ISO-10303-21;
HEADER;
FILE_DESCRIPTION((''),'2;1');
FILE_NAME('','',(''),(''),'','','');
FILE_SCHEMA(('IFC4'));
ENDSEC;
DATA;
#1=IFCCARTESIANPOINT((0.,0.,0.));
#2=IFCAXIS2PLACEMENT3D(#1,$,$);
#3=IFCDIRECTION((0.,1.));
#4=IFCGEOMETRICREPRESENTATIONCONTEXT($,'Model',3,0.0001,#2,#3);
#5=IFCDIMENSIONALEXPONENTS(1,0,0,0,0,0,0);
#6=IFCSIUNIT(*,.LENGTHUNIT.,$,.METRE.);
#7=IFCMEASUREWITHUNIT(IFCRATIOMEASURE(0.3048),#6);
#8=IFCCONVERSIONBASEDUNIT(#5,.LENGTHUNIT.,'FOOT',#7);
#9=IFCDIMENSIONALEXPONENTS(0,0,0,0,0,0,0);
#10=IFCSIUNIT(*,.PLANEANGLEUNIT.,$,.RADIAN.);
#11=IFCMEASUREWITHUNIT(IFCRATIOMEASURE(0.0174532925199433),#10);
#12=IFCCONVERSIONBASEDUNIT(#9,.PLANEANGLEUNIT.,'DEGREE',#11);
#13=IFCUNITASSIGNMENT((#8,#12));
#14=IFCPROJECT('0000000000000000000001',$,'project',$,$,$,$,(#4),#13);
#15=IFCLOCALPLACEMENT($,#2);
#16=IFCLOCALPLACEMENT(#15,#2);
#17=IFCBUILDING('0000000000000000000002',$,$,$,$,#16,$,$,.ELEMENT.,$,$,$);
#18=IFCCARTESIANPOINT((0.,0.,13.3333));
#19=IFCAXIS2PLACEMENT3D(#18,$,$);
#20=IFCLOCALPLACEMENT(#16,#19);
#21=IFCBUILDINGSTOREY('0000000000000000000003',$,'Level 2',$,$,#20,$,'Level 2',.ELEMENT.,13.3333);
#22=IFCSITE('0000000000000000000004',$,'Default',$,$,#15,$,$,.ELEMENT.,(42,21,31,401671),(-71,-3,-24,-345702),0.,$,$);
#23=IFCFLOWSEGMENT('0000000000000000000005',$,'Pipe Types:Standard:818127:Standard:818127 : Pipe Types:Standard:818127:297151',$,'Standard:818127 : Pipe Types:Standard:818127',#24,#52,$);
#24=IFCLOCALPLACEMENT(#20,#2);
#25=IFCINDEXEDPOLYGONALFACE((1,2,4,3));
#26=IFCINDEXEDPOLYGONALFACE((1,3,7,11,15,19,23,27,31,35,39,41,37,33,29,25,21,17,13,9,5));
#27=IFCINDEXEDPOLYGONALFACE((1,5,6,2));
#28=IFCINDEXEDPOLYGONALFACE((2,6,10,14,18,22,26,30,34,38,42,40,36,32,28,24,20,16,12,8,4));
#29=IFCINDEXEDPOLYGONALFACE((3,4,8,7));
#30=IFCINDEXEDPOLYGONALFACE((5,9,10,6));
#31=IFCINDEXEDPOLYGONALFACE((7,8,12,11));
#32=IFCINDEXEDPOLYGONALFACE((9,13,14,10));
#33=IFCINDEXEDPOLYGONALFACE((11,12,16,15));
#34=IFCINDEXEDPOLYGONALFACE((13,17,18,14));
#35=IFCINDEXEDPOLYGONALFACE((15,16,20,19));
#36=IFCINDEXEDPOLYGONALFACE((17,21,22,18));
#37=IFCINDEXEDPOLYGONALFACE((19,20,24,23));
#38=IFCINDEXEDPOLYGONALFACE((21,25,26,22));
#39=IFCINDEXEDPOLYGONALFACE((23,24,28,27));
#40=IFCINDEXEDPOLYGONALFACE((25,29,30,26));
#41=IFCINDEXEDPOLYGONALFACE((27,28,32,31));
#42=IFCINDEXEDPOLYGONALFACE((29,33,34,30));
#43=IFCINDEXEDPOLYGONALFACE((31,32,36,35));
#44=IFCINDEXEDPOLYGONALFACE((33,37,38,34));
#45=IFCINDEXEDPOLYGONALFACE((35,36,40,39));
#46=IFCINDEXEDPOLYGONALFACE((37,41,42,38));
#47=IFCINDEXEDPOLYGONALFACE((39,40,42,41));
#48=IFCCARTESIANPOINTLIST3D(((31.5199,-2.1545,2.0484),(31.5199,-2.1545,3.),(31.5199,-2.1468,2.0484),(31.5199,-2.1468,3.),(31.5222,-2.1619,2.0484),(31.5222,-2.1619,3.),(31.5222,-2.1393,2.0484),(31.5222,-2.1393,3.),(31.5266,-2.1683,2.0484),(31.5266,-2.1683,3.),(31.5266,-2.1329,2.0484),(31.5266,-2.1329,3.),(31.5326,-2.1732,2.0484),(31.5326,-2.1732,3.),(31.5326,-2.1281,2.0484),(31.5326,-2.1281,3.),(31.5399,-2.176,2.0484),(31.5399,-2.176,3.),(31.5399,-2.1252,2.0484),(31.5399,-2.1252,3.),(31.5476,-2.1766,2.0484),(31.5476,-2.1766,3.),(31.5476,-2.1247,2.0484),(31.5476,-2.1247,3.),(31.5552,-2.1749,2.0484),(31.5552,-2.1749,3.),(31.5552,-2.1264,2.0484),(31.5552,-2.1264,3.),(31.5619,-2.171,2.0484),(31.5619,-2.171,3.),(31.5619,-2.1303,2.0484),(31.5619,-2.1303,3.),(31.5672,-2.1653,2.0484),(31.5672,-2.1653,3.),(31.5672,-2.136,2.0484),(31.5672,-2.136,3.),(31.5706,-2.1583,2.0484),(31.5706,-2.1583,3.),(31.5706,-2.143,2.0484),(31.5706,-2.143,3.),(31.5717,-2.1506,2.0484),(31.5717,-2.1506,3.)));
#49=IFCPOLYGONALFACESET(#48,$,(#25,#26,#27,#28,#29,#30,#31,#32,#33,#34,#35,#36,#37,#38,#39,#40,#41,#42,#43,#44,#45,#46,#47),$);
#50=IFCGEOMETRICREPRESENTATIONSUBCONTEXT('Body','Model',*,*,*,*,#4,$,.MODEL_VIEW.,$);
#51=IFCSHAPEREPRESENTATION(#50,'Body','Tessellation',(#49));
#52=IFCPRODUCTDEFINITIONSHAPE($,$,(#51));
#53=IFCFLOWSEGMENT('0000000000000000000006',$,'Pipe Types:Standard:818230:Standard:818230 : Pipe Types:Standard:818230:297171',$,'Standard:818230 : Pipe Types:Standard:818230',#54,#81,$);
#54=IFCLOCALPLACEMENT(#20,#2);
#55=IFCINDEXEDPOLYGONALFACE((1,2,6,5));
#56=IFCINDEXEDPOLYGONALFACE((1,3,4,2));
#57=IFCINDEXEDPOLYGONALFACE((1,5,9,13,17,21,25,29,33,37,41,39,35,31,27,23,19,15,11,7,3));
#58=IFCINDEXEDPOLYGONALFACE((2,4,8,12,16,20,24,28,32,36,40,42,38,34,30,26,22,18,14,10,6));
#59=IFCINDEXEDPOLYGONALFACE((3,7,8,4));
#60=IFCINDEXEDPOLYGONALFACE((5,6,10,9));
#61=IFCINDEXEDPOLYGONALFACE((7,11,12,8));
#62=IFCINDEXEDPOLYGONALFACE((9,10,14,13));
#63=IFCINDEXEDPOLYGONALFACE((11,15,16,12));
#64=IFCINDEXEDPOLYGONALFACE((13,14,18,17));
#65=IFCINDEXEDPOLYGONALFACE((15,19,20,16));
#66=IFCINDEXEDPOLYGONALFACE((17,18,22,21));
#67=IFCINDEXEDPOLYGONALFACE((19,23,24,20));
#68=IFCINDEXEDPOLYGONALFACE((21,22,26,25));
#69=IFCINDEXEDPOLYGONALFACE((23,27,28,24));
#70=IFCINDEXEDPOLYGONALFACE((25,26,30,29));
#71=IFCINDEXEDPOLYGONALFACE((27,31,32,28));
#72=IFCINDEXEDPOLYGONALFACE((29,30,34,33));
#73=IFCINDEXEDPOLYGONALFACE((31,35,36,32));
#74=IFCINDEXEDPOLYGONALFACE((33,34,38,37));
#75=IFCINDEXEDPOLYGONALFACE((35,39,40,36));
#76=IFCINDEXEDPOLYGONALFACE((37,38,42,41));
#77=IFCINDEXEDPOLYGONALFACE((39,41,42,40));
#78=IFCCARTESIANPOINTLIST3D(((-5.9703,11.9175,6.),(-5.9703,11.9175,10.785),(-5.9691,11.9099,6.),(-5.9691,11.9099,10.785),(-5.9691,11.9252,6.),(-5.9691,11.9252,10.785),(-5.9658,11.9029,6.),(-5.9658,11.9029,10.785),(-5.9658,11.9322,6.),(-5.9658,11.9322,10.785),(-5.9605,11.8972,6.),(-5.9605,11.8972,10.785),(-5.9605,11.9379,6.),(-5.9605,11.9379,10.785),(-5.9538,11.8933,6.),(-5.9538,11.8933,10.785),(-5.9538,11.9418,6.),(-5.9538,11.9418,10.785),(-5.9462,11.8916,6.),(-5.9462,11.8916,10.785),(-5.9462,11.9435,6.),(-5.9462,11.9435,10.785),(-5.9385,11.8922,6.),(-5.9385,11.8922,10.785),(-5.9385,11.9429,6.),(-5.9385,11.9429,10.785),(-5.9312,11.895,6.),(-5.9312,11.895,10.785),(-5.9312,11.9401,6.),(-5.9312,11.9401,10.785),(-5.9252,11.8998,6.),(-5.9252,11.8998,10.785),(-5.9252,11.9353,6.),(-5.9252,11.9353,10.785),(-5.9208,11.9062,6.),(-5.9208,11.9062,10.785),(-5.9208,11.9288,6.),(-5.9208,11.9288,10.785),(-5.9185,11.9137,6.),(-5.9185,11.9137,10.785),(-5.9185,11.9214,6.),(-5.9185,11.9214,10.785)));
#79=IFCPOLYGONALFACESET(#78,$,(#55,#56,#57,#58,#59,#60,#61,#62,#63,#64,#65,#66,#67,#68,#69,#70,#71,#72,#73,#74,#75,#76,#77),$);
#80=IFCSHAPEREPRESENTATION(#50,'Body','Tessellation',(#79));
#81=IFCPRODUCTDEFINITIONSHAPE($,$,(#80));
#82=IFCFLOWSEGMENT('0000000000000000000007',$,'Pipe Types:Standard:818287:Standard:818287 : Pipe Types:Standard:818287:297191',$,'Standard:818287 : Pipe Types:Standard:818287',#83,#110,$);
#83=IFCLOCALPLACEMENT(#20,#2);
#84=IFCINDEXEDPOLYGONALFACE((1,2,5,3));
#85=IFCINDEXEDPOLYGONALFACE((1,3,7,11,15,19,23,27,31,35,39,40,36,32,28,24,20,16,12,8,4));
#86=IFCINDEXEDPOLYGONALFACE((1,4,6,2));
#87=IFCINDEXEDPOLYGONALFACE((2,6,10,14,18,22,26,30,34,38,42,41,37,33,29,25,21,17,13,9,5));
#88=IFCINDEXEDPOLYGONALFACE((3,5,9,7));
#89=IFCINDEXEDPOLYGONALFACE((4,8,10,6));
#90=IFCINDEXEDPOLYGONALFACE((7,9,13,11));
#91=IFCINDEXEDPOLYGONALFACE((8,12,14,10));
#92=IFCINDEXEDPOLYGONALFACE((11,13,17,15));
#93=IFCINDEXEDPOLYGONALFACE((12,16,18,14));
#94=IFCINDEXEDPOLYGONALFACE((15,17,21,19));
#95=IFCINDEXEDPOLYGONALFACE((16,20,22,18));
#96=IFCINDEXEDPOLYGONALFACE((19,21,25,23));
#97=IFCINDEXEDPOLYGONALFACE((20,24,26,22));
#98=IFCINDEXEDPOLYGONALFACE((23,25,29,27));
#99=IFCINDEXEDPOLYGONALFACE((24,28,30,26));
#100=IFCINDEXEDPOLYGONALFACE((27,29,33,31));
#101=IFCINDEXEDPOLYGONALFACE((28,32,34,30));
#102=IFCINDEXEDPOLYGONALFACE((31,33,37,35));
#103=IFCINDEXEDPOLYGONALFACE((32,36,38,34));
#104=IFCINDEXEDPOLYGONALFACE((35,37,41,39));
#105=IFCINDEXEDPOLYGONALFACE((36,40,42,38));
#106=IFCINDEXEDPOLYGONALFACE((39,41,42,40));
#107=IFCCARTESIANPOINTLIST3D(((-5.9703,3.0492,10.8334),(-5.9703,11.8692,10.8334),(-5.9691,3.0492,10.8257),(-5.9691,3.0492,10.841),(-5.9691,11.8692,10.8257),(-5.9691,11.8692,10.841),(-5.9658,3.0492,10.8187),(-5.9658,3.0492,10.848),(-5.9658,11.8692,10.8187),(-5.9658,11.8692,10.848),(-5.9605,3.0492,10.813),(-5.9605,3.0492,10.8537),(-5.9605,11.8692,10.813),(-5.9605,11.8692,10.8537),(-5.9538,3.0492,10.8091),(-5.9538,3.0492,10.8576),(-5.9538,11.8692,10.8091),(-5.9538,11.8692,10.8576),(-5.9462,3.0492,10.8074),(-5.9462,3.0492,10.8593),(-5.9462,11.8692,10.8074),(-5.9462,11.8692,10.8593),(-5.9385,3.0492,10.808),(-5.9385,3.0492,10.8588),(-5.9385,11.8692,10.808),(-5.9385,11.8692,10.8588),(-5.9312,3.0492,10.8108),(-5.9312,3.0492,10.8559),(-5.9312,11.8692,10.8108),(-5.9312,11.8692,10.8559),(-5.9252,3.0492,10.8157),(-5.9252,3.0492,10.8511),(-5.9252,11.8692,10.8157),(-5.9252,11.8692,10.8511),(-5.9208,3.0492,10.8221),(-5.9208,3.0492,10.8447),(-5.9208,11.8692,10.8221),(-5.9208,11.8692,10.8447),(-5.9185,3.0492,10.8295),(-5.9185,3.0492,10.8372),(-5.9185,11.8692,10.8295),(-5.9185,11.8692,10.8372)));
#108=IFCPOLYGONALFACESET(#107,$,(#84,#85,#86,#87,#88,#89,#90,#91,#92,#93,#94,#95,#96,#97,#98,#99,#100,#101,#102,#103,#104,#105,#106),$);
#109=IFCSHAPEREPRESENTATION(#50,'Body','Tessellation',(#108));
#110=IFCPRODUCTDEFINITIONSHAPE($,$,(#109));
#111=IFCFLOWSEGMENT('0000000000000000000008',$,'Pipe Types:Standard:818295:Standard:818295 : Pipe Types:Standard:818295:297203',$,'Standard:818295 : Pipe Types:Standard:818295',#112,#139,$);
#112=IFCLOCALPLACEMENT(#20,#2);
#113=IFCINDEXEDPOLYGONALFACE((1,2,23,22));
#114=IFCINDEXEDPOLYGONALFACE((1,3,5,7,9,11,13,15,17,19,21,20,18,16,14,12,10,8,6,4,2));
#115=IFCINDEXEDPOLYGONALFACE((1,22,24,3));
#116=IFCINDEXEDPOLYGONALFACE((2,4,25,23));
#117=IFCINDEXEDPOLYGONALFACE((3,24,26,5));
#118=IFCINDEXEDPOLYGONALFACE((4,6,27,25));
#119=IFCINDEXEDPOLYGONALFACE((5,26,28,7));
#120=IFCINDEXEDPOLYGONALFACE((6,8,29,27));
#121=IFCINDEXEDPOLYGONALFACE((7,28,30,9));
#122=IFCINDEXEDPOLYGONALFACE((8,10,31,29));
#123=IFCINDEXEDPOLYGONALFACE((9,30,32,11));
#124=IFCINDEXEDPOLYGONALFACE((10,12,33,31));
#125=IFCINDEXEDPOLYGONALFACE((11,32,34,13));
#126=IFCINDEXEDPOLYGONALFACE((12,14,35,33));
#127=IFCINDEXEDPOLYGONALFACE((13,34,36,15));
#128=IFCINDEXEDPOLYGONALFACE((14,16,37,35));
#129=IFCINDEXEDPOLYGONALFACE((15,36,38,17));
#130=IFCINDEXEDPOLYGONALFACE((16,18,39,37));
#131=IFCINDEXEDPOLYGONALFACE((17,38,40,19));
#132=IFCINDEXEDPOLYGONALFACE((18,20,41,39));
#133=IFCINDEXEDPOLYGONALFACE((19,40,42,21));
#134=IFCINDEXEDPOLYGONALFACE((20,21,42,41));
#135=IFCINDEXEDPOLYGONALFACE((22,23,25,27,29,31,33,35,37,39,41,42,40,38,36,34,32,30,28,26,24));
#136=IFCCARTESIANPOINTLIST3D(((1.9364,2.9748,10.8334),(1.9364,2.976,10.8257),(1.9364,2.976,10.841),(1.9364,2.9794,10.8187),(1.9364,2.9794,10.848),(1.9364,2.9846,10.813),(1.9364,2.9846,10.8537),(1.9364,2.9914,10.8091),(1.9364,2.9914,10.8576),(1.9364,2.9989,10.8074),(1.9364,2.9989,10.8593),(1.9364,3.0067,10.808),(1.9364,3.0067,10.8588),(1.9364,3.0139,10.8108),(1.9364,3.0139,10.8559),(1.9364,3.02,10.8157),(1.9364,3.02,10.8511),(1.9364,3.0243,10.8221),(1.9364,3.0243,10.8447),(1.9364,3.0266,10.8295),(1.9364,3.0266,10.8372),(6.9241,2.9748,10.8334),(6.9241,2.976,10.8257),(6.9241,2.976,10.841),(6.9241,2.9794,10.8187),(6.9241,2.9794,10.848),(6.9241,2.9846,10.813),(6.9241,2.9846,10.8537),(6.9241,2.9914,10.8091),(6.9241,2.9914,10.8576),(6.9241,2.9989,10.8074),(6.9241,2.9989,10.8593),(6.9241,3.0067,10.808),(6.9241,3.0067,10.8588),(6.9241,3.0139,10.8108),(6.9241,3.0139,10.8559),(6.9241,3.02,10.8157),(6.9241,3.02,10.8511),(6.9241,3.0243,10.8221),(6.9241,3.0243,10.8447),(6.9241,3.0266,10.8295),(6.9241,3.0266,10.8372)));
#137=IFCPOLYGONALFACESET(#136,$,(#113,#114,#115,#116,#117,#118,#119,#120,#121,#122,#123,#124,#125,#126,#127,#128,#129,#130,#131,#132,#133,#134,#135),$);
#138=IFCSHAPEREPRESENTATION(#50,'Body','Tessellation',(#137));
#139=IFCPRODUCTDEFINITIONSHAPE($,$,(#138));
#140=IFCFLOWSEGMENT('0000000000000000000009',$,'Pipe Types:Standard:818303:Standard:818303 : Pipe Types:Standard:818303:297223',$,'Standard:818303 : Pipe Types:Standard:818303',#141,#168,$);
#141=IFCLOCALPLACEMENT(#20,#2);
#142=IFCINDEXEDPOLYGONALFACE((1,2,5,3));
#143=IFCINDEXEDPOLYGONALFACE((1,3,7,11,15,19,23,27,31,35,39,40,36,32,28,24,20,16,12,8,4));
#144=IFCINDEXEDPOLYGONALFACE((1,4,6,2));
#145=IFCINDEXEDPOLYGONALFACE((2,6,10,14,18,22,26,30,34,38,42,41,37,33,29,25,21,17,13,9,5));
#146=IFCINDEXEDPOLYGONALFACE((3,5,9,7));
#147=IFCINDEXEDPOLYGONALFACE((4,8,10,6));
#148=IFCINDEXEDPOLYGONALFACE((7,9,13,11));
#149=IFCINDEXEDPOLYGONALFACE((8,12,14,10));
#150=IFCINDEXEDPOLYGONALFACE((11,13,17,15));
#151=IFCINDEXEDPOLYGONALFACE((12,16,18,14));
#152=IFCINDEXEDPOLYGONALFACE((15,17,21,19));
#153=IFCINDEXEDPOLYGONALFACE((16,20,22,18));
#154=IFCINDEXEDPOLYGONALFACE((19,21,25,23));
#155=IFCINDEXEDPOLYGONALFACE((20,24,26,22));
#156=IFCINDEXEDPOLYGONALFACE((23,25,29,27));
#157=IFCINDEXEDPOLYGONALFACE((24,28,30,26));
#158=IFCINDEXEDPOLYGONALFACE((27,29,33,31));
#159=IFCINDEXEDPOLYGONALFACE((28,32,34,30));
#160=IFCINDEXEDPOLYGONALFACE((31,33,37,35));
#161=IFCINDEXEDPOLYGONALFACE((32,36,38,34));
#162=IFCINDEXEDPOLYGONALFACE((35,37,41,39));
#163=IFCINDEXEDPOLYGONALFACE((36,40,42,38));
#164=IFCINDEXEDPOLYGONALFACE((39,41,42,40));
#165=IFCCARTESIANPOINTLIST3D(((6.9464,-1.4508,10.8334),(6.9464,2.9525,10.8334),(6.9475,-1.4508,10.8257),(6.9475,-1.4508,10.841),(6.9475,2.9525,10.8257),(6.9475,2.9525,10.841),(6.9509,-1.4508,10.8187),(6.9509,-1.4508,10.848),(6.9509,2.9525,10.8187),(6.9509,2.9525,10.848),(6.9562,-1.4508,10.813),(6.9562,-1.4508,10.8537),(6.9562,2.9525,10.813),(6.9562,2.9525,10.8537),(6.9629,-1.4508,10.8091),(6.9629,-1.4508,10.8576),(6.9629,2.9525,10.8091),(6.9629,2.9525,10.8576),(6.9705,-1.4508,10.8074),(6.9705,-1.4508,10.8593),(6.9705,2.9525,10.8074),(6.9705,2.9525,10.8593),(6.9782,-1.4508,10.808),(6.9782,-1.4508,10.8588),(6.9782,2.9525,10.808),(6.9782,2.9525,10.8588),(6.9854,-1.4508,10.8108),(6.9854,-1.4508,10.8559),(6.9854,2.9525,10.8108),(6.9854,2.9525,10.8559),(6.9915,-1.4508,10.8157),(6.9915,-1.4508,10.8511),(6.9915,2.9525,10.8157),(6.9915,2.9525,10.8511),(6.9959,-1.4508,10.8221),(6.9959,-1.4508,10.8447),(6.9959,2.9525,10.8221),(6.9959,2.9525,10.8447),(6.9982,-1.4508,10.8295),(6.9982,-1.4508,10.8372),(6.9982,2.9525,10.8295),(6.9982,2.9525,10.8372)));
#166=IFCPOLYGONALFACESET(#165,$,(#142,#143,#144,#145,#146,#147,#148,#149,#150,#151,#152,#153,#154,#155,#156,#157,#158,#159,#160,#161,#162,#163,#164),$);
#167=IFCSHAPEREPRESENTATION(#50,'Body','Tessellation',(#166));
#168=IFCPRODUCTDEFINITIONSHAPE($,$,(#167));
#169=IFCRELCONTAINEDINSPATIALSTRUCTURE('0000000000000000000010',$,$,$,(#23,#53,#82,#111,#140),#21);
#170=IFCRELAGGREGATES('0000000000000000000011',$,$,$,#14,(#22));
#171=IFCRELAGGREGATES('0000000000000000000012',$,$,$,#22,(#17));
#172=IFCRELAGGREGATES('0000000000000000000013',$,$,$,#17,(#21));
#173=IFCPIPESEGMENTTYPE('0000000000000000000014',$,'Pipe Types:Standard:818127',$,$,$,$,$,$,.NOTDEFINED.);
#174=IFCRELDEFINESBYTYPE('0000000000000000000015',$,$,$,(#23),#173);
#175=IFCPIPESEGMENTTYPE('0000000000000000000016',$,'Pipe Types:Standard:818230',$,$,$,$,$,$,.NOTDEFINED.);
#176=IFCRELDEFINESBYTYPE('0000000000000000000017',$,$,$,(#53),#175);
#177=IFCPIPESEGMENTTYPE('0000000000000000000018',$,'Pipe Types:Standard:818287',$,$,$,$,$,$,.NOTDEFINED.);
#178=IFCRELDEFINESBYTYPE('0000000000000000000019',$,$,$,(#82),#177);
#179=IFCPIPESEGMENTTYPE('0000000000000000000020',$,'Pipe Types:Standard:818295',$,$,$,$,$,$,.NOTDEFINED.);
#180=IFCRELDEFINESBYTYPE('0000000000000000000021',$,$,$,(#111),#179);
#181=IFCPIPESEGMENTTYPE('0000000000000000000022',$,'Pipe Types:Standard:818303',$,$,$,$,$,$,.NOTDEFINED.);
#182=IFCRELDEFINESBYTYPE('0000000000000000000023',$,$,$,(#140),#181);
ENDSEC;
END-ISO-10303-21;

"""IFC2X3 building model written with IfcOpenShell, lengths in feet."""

from ifc_helpers import new_model, entity, si_unit, converted_unit, direction, frame, origin, origin_2d_with_axis, place, context, subcontext, project, spatial, circle, extrude, source, transform, mapped, type_object, type_shapes, element, save


model = new_model("IFC2X3")

# Units and contexts
model_context = context("Model", 3, precision=0.0001, world=origin(), true_north=direction((0.0, 1.0)))
body_context = subcontext(model_context, "Body", "Model", "MODEL_VIEW")
ifc_project = project(units=[converted_unit("LENGTHUNIT", "FOOT", entity("IfcRatioMeasure", 0.3048), si_unit("LENGTHUNIT", "METRE"), dimensions=[1, 0, 0, 0, 0, 0, 0]), converted_unit("PLANEANGLEUNIT", "DEGREE", entity("IfcRatioMeasure", 0.0174532925199433), si_unit("PLANEANGLEUNIT", "RADIAN"), dimensions=[0, 0, 0, 0, 0, 0, 0])], contexts=[model_context])

# Site, building, storey
site_placement = place(None, origin())
site = spatial("IfcSite", under=ifc_project, at=site_placement, Name="Default", CompositionType="ELEMENT", RefLatitude=(42, 21, 31, 401671), RefLongitude=(-71, -3, -24, -345702), RefElevation=0.0)
building_placement = place(site_placement, origin())
building = spatial("IfcBuilding", under=site, at=building_placement, CompositionType="ELEMENT")
storey_placement = place(building_placement, frame((0.0, 0.0, 13.3333)))
storey = spatial("IfcBuildingStorey", under=building, at=storey_placement, Name="Level 2", LongName="Level 2", CompositionType="ELEMENT", Elevation=13.3333)

# Flow segments
pipe_segment_type_1 = type_object("IfcPipeSegmentType", Name="Pipe Types:Standard:818127", PredefinedType="NOTDEFINED")
shared_shape_1 = source(origin(), body_context, "Body", "SweptSolid", [
    extrude(circle(Radius=0.026, at=origin_2d_with_axis()), frame((31.5457, -2.1506, 15.3817)), (0.0, 0.0, 1.0), 0.9517),
])
type_shapes(pipe_segment_type_1, [shared_shape_1])
flow_segment_1_placement = place(building_placement, origin())
element("IfcFlowSegment", 1, at=flow_segment_1_placement, inside=storey, type_object=pipe_segment_type_1, Name="Pipe Types:Standard:818127:Standard:818127 : Pipe Types:Standard:818127:297151", ObjectType="Standard:818127 : Pipe Types:Standard:818127", context=body_context, shape_type="MappedRepresentation", body=[
    mapped(shared_shape_1, transform((0.0, 0.0, 0.0), scale=1.0)),
])
pipe_segment_type_2 = type_object("IfcPipeSegmentType", Name="Pipe Types:Standard:818230", PredefinedType="NOTDEFINED")
shared_shape_2 = source(origin(), body_context, "Body", "SweptSolid", [
    extrude(circle(Radius=0.026, at=origin_2d_with_axis()), frame((-5.9442, 11.9175, 19.3333), z_axis=(0.0, 0.0, 1.0), x_axis=(-1.0, 0.0, 0.0)), (0.0, 0.0, 1.0), 4.785),
])
type_shapes(pipe_segment_type_2, [shared_shape_2])
flow_segment_2_placement = place(building_placement, origin())
element("IfcFlowSegment", 2, at=flow_segment_2_placement, inside=storey, type_object=pipe_segment_type_2, Name="Pipe Types:Standard:818230:Standard:818230 : Pipe Types:Standard:818230:297171", ObjectType="Standard:818230 : Pipe Types:Standard:818230", context=body_context, shape_type="MappedRepresentation", body=[
    mapped(shared_shape_2, transform((0.0, 0.0, 0.0), scale=1.0)),
])
pipe_segment_type_3 = type_object("IfcPipeSegmentType", Name="Pipe Types:Standard:818287", PredefinedType="NOTDEFINED")
shared_shape_3 = source(origin(), body_context, "Body", "SweptSolid", [
    extrude(circle(Radius=0.026, at=origin_2d_with_axis()), frame((-5.9442, 3.0492, 24.1667), z_axis=(0.0, 1.0, 0.0), x_axis=(-1.0, 0.0, 0.0)), (0.0, 0.0, 1.0), 8.82),
])
type_shapes(pipe_segment_type_3, [shared_shape_3])
flow_segment_3_placement = place(building_placement, origin())
element("IfcFlowSegment", 3, at=flow_segment_3_placement, inside=storey, type_object=pipe_segment_type_3, Name="Pipe Types:Standard:818287:Standard:818287 : Pipe Types:Standard:818287:297191", ObjectType="Standard:818287 : Pipe Types:Standard:818287", context=body_context, shape_type="MappedRepresentation", body=[
    mapped(shared_shape_3, transform((0.0, 0.0, 0.0), scale=1.0)),
])
pipe_segment_type_4 = type_object("IfcPipeSegmentType", Name="Pipe Types:Standard:818295", PredefinedType="NOTDEFINED")
shared_shape_4 = source(origin(), body_context, "Body", "SweptSolid", [
    extrude(circle(Radius=0.026, at=origin_2d_with_axis()), frame((1.9364, 3.0009, 24.1667), z_axis=(1.0, 0.0, 0.0), x_axis=(0.0, -1.0, 0.0)), (0.0, 0.0, 1.0), 4.9877),
])
type_shapes(pipe_segment_type_4, [shared_shape_4])
flow_segment_4_placement = place(building_placement, origin())
element("IfcFlowSegment", 4, at=flow_segment_4_placement, inside=storey, type_object=pipe_segment_type_4, Name="Pipe Types:Standard:818295:Standard:818295 : Pipe Types:Standard:818295:297203", ObjectType="Standard:818295 : Pipe Types:Standard:818295", context=body_context, shape_type="MappedRepresentation", body=[
    mapped(shared_shape_4, transform((0.0, 0.0, 0.0), scale=1.0)),
])
pipe_segment_type_5 = type_object("IfcPipeSegmentType", Name="Pipe Types:Standard:818303", PredefinedType="NOTDEFINED")
shared_shape_5 = source(origin(), body_context, "Body", "SweptSolid", [
    extrude(circle(Radius=0.026, at=origin_2d_with_axis()), frame((6.9724, -1.4508, 24.1667), z_axis=(0.0, 1.0, 0.0), x_axis=(-1.0, 0.0, 0.0)), (0.0, 0.0, 1.0), 4.4033),
])
type_shapes(pipe_segment_type_5, [shared_shape_5])
flow_segment_5_placement = place(building_placement, origin())
element("IfcFlowSegment", 5, at=flow_segment_5_placement, inside=storey, type_object=pipe_segment_type_5, Name="Pipe Types:Standard:818303:Standard:818303 : Pipe Types:Standard:818303:297223", ObjectType="Standard:818303 : Pipe Types:Standard:818303", context=body_context, shape_type="MappedRepresentation", body=[
    mapped(shared_shape_5, transform((0.0, 0.0, 0.0), scale=1.0)),
])

save(model, "model.ifc")
